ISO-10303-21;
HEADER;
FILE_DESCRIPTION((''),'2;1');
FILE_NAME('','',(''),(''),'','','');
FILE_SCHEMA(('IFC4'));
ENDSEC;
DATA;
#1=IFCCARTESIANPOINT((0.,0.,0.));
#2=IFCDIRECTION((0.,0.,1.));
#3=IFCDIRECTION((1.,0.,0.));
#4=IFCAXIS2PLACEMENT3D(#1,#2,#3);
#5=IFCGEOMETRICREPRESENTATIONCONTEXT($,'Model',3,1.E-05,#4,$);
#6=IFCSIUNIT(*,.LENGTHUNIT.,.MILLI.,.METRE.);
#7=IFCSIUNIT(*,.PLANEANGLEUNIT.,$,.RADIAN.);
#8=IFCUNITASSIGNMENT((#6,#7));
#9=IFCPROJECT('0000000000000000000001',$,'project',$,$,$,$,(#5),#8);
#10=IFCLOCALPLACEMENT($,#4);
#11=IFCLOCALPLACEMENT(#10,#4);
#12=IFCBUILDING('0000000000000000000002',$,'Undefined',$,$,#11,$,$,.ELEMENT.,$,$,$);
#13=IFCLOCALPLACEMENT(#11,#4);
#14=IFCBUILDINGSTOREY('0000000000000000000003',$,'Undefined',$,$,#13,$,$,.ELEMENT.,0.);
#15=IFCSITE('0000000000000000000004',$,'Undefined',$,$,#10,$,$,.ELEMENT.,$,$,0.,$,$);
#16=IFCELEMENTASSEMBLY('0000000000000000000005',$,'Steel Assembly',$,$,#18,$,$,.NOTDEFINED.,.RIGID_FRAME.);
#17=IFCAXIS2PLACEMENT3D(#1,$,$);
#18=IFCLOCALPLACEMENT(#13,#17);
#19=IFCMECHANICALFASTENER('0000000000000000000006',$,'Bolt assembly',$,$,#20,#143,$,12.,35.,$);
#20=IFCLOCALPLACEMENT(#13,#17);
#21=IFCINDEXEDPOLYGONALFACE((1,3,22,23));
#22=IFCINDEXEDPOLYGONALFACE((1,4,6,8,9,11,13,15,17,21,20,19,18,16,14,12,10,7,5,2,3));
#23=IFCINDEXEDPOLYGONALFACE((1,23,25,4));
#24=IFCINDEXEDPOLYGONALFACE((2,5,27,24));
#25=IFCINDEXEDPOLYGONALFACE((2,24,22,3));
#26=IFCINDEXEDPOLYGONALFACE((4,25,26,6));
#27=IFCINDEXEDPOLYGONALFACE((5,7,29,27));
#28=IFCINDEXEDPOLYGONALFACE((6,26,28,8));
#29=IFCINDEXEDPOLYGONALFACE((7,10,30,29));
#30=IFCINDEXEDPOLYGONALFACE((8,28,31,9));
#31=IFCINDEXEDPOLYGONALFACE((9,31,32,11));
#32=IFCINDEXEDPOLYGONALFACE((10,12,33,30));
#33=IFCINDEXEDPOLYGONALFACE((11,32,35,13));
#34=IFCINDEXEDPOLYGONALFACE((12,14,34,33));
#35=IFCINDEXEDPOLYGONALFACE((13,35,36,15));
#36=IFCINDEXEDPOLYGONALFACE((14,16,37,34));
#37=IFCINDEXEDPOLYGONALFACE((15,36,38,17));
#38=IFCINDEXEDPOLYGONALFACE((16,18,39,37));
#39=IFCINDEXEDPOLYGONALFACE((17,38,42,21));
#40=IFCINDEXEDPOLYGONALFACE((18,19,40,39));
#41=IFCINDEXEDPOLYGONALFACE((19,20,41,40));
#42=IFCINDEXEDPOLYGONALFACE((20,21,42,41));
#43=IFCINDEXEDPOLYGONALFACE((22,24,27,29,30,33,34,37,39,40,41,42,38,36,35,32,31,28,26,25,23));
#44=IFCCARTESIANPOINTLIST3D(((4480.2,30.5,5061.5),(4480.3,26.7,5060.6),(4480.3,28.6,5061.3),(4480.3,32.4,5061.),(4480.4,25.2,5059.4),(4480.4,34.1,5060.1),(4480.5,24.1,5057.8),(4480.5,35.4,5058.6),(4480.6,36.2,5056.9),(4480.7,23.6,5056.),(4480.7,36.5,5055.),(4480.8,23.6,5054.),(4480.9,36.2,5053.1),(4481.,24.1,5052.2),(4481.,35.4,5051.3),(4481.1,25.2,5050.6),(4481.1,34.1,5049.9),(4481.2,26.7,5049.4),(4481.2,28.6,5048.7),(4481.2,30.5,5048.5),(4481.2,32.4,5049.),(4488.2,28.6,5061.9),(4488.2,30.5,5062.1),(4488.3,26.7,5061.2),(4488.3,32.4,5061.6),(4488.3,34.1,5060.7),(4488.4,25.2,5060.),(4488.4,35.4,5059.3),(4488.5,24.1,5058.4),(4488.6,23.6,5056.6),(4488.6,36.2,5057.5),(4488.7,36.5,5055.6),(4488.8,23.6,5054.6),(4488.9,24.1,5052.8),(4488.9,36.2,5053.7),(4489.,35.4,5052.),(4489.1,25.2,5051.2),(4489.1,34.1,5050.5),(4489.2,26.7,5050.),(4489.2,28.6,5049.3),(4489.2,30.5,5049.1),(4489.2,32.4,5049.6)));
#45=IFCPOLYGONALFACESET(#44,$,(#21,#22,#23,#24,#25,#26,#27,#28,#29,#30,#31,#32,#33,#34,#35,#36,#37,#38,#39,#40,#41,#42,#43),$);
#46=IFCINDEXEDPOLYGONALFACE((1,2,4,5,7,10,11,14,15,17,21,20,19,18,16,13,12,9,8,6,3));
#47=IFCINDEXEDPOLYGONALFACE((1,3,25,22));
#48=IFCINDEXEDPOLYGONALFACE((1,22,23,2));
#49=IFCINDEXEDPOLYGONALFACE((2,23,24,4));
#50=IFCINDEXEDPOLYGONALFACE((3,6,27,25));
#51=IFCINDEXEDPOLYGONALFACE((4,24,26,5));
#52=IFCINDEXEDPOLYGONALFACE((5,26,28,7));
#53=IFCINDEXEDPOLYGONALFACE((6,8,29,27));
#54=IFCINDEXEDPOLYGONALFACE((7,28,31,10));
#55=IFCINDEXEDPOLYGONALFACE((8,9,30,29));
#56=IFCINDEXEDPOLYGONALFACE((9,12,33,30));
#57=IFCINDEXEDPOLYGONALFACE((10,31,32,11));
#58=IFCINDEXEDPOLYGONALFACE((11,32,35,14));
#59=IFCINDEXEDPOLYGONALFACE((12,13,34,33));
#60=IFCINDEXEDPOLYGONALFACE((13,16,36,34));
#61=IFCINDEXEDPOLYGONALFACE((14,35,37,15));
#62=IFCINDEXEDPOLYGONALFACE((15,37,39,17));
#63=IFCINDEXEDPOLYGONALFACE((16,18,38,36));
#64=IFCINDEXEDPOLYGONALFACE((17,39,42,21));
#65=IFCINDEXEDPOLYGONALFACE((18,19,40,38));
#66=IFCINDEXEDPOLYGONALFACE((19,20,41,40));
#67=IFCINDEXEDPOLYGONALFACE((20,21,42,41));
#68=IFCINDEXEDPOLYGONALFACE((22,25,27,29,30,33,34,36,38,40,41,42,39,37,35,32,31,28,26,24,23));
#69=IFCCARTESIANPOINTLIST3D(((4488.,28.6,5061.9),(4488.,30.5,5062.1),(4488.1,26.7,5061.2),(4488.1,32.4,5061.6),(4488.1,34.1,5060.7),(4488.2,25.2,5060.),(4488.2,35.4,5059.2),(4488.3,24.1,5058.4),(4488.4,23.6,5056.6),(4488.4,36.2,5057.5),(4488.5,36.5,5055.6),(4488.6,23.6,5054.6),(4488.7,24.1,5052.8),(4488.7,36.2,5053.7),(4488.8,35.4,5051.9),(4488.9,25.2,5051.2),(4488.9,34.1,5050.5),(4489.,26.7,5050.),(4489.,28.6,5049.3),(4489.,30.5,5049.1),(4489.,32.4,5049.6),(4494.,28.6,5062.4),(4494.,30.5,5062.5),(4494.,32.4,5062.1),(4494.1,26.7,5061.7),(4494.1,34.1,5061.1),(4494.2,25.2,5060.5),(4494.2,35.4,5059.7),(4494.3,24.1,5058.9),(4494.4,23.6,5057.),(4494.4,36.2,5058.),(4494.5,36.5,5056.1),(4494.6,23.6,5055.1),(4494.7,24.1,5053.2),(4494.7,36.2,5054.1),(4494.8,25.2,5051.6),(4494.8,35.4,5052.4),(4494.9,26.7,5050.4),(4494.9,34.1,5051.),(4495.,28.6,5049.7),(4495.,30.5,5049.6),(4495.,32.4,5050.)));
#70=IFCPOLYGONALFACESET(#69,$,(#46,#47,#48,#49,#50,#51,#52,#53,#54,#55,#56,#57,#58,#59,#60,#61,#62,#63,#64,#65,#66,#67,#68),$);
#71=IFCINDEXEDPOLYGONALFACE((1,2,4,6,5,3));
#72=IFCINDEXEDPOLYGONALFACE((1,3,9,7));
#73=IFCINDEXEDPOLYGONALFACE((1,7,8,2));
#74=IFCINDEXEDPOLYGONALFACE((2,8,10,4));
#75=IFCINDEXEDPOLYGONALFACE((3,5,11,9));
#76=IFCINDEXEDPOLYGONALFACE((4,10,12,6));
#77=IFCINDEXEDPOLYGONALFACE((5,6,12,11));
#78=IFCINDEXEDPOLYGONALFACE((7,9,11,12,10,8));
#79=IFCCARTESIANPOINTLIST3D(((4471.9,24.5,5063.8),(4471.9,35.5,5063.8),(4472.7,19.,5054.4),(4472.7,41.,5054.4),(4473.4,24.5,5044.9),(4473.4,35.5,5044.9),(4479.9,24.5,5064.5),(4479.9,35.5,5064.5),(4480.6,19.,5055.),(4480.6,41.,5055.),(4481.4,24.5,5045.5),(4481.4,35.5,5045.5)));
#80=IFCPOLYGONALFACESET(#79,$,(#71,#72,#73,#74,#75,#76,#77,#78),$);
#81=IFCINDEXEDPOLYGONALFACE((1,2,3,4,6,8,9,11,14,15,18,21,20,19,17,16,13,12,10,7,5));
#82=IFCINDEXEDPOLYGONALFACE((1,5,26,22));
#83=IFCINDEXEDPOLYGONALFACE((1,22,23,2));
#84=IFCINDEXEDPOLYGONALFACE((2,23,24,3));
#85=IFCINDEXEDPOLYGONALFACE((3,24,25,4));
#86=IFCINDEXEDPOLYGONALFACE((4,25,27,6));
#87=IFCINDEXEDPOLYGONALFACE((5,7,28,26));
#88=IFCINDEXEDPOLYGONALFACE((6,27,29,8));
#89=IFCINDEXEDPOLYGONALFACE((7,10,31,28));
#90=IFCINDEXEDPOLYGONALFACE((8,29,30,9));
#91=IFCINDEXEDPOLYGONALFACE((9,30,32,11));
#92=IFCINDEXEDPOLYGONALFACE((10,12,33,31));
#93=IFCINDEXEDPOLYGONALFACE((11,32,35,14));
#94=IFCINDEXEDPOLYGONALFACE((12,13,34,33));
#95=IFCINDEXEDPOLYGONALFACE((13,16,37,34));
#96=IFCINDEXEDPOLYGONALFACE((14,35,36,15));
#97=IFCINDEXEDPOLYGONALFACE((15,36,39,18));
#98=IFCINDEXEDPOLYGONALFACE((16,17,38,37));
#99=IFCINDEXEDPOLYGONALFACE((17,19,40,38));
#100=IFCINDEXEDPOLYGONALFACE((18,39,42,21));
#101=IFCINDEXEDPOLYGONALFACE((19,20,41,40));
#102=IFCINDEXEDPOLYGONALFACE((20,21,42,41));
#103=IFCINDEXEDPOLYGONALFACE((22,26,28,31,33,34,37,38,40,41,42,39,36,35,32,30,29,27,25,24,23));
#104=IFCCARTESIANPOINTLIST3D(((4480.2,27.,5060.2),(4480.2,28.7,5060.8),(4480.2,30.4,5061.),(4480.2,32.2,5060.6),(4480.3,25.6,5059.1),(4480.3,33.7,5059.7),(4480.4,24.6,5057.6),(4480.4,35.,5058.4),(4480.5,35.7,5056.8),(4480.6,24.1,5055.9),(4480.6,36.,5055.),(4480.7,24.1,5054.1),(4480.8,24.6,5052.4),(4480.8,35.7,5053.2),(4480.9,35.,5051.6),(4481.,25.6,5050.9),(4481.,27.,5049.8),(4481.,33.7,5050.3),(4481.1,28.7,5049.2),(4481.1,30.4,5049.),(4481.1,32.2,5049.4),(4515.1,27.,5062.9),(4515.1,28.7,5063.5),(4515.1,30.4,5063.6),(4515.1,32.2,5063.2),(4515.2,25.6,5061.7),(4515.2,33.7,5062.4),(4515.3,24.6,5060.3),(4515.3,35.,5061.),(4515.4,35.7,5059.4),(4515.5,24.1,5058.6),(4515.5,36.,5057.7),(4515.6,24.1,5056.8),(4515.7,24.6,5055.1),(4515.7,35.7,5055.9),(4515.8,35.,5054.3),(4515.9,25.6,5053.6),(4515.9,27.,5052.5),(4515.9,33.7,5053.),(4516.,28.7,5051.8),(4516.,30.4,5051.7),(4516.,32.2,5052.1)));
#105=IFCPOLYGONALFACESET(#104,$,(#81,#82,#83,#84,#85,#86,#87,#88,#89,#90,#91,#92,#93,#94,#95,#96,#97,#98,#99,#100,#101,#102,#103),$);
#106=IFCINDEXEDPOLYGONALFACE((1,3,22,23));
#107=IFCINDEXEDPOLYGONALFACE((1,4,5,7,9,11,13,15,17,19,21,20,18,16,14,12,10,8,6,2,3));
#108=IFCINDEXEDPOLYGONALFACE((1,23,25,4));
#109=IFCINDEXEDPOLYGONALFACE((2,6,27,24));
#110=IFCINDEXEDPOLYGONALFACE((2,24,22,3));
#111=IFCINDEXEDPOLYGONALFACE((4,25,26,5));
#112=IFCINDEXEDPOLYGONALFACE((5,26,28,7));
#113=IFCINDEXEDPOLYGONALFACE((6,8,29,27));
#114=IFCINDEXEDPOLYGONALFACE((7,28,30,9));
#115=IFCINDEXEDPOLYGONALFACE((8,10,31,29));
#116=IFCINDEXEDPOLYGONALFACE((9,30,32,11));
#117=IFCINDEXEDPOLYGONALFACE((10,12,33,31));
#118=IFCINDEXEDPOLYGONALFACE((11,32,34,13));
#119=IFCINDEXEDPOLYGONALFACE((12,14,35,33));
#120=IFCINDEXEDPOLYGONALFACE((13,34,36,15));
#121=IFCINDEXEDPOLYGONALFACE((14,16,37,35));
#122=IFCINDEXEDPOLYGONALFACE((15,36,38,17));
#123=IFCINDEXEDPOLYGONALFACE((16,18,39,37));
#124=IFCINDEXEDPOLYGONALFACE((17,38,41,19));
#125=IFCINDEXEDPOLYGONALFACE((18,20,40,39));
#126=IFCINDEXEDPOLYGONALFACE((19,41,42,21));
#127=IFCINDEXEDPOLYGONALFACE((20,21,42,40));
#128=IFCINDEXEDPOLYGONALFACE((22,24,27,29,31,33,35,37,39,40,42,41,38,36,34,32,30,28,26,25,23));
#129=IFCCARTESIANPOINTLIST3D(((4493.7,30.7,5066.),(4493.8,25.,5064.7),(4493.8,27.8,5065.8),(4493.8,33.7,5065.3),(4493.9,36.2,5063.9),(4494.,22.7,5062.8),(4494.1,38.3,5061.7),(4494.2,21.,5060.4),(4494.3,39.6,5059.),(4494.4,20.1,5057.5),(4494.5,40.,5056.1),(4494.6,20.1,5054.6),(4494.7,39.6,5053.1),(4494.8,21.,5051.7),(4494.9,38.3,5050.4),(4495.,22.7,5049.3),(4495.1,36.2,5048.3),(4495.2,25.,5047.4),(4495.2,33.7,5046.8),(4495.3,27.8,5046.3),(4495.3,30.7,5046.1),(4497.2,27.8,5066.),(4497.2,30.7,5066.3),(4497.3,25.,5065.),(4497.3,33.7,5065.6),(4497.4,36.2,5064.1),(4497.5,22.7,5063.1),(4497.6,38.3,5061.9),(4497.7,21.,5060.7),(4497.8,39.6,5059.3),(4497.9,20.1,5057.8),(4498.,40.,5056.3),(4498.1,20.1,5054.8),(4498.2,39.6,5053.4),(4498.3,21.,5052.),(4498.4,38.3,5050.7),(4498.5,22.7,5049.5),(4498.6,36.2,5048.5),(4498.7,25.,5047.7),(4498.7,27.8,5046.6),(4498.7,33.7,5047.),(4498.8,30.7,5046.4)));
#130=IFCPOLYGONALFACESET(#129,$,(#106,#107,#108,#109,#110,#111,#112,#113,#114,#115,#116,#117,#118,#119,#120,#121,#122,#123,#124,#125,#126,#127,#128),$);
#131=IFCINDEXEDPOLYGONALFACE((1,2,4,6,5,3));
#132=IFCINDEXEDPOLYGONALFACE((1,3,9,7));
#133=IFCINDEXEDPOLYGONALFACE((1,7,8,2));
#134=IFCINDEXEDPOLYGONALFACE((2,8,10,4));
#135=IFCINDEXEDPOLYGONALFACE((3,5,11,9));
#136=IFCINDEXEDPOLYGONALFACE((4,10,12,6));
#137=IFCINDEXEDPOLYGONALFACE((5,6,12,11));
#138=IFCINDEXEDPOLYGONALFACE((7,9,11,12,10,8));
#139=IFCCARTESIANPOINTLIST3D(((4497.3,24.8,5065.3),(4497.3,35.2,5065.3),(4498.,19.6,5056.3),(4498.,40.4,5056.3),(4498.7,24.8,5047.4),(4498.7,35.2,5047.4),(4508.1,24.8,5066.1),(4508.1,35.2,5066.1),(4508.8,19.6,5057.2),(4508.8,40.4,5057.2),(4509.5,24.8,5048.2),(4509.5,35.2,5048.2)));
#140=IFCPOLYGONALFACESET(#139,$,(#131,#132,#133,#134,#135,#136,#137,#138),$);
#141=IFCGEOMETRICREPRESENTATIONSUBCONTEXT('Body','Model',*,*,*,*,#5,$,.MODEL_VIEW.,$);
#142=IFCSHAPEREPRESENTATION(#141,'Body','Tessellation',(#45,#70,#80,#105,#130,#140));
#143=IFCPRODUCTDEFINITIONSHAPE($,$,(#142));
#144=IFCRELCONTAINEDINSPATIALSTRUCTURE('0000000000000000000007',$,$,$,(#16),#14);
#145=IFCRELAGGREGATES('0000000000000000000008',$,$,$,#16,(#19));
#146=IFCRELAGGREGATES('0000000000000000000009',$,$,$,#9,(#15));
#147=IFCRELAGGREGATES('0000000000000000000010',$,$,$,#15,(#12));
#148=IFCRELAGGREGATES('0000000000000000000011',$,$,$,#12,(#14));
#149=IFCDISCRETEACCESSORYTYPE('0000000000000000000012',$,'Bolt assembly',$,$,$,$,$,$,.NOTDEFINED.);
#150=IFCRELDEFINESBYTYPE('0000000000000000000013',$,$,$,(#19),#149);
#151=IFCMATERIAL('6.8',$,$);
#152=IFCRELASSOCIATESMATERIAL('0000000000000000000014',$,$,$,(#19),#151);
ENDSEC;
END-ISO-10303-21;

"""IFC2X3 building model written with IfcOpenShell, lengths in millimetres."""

from ifc_helpers import new_model, si_unit, frame, origin_with_axes, origin_2d_with_axis, place, context, subcontext, project, spatial, polyline, circle, outline, extrude, source, transform, mapped, material, type_object, element, aggregate, save


model = new_model("IFC2X3")

# Units and contexts
model_context = context("Model", 3, precision=1e-05, world=origin_with_axes())
body_context = subcontext(model_context, "Body", "Model", "MODEL_VIEW")
ifc_project = project(units=[si_unit("LENGTHUNIT", "METRE", prefix="MILLI"), si_unit("PLANEANGLEUNIT", "RADIAN")], contexts=[model_context])

# Site, building, storey
site_placement = place(None, origin_with_axes())
site = spatial("IfcSite", under=ifc_project, at=site_placement, Name="Undefined", CompositionType="ELEMENT", RefElevation=0.0)
building_placement = place(site_placement, origin_with_axes())
building = spatial("IfcBuilding", under=site, at=building_placement, Name="Undefined", CompositionType="ELEMENT")
storey_placement = place(building_placement, origin_with_axes())
storey = spatial("IfcBuildingStorey", under=building, at=storey_placement, Name="Undefined", CompositionType="ELEMENT", Elevation=0.0)

# Element assembly, mechanical fastener
ifc_material_1 = material(Name="6.8")
discrete_accessory_type_1 = type_object("IfcDiscreteAccessoryType", Name="Bolt assembly")
shared_shape_1 = source(origin_with_axes(), body_context, "Body", "SweptSolid", [
    extrude(circle(Radius=6.5, at=origin_2d_with_axis()), frame((0.0, -10.9, 0.0), z_axis=(0.0, 1.0, 0.0), x_axis=(1.0, 0.0, 0.0)), (0.0, 0.0, 1.0), 8.0),
    extrude(circle(Radius=6.5, at=origin_2d_with_axis()), frame((0.0, -3.1, 0.0), z_axis=(0.0, 1.0, 0.0), x_axis=(1.0, 0.0, 0.0)), (0.0, 0.0, 1.0), 6.0),
    extrude(outline(polyline([(11.0, 0.0), (5.5, 9.5), (-5.5, 9.5), (-11.0, 0.0), (-5.5, -9.5), (5.5, -9.5), (11.0, 0.0)])), frame((0.0, -19.0, 0.0), z_axis=(0.0, 1.0, 0.0), x_axis=(1.0, 0.0, 0.0)), (0.0, 0.0, 1.0), 8.0),
    extrude(circle(Radius=6.0, at=origin_2d_with_axis()), frame((0.0, -11.0, 0.0), z_axis=(0.0, 1.0, 0.0), x_axis=(1.0, 0.0, 0.0)), (0.0, 0.0, 1.0), 35.0),
    extrude(circle(Radius=10.0, at=origin_2d_with_axis()), frame((0.0, 3.0, 0.0), z_axis=(0.0, 1.0, 0.0), x_axis=(1.0, 0.0, 0.0)), (0.0, 0.0, 1.0), 3.5),
    extrude(outline(polyline([(10.4, 0.0), (5.2, 9.0), (-5.2, 9.0), (-10.4, 0.0), (-5.2, -9.0), (5.2, -9.0), (10.4, 0.0)])), frame((0.0, 6.5, 0.0), z_axis=(0.0, 1.0, 0.0), x_axis=(1.0, 0.0, 0.0)), (0.0, 0.0, 1.0), 10.8),
])
assembly_1_placement = place(storey_placement, origin_with_axes())
assembly_1 = element("IfcElementAssembly", 1, at=assembly_1_placement, inside=storey, Name="Steel Assembly", AssemblyPlace="NOTDEFINED", PredefinedType="RIGID_FRAME")
mechanical_fastener_1_placement = place(assembly_1_placement, frame((4491.6, 30.0, 5055.8), z_axis=(0.076696, 0.0, -0.997054), x_axis=(0.0, 1.0, 0.0)))
mechanical_fastener_1 = element("IfcMechanicalFastener", 2, at=mechanical_fastener_1_placement, type_object=discrete_accessory_type_1, material=ifc_material_1, Name="Bolt assembly", NominalDiameter=12.0, NominalLength=35.0, context=body_context, shape_type="MappedRepresentation", body=[
    mapped(shared_shape_1, transform((0.0, 0.0, 0.0))),
])
aggregate(assembly_1, [mechanical_fastener_1])

save(model, "model.ifc")
